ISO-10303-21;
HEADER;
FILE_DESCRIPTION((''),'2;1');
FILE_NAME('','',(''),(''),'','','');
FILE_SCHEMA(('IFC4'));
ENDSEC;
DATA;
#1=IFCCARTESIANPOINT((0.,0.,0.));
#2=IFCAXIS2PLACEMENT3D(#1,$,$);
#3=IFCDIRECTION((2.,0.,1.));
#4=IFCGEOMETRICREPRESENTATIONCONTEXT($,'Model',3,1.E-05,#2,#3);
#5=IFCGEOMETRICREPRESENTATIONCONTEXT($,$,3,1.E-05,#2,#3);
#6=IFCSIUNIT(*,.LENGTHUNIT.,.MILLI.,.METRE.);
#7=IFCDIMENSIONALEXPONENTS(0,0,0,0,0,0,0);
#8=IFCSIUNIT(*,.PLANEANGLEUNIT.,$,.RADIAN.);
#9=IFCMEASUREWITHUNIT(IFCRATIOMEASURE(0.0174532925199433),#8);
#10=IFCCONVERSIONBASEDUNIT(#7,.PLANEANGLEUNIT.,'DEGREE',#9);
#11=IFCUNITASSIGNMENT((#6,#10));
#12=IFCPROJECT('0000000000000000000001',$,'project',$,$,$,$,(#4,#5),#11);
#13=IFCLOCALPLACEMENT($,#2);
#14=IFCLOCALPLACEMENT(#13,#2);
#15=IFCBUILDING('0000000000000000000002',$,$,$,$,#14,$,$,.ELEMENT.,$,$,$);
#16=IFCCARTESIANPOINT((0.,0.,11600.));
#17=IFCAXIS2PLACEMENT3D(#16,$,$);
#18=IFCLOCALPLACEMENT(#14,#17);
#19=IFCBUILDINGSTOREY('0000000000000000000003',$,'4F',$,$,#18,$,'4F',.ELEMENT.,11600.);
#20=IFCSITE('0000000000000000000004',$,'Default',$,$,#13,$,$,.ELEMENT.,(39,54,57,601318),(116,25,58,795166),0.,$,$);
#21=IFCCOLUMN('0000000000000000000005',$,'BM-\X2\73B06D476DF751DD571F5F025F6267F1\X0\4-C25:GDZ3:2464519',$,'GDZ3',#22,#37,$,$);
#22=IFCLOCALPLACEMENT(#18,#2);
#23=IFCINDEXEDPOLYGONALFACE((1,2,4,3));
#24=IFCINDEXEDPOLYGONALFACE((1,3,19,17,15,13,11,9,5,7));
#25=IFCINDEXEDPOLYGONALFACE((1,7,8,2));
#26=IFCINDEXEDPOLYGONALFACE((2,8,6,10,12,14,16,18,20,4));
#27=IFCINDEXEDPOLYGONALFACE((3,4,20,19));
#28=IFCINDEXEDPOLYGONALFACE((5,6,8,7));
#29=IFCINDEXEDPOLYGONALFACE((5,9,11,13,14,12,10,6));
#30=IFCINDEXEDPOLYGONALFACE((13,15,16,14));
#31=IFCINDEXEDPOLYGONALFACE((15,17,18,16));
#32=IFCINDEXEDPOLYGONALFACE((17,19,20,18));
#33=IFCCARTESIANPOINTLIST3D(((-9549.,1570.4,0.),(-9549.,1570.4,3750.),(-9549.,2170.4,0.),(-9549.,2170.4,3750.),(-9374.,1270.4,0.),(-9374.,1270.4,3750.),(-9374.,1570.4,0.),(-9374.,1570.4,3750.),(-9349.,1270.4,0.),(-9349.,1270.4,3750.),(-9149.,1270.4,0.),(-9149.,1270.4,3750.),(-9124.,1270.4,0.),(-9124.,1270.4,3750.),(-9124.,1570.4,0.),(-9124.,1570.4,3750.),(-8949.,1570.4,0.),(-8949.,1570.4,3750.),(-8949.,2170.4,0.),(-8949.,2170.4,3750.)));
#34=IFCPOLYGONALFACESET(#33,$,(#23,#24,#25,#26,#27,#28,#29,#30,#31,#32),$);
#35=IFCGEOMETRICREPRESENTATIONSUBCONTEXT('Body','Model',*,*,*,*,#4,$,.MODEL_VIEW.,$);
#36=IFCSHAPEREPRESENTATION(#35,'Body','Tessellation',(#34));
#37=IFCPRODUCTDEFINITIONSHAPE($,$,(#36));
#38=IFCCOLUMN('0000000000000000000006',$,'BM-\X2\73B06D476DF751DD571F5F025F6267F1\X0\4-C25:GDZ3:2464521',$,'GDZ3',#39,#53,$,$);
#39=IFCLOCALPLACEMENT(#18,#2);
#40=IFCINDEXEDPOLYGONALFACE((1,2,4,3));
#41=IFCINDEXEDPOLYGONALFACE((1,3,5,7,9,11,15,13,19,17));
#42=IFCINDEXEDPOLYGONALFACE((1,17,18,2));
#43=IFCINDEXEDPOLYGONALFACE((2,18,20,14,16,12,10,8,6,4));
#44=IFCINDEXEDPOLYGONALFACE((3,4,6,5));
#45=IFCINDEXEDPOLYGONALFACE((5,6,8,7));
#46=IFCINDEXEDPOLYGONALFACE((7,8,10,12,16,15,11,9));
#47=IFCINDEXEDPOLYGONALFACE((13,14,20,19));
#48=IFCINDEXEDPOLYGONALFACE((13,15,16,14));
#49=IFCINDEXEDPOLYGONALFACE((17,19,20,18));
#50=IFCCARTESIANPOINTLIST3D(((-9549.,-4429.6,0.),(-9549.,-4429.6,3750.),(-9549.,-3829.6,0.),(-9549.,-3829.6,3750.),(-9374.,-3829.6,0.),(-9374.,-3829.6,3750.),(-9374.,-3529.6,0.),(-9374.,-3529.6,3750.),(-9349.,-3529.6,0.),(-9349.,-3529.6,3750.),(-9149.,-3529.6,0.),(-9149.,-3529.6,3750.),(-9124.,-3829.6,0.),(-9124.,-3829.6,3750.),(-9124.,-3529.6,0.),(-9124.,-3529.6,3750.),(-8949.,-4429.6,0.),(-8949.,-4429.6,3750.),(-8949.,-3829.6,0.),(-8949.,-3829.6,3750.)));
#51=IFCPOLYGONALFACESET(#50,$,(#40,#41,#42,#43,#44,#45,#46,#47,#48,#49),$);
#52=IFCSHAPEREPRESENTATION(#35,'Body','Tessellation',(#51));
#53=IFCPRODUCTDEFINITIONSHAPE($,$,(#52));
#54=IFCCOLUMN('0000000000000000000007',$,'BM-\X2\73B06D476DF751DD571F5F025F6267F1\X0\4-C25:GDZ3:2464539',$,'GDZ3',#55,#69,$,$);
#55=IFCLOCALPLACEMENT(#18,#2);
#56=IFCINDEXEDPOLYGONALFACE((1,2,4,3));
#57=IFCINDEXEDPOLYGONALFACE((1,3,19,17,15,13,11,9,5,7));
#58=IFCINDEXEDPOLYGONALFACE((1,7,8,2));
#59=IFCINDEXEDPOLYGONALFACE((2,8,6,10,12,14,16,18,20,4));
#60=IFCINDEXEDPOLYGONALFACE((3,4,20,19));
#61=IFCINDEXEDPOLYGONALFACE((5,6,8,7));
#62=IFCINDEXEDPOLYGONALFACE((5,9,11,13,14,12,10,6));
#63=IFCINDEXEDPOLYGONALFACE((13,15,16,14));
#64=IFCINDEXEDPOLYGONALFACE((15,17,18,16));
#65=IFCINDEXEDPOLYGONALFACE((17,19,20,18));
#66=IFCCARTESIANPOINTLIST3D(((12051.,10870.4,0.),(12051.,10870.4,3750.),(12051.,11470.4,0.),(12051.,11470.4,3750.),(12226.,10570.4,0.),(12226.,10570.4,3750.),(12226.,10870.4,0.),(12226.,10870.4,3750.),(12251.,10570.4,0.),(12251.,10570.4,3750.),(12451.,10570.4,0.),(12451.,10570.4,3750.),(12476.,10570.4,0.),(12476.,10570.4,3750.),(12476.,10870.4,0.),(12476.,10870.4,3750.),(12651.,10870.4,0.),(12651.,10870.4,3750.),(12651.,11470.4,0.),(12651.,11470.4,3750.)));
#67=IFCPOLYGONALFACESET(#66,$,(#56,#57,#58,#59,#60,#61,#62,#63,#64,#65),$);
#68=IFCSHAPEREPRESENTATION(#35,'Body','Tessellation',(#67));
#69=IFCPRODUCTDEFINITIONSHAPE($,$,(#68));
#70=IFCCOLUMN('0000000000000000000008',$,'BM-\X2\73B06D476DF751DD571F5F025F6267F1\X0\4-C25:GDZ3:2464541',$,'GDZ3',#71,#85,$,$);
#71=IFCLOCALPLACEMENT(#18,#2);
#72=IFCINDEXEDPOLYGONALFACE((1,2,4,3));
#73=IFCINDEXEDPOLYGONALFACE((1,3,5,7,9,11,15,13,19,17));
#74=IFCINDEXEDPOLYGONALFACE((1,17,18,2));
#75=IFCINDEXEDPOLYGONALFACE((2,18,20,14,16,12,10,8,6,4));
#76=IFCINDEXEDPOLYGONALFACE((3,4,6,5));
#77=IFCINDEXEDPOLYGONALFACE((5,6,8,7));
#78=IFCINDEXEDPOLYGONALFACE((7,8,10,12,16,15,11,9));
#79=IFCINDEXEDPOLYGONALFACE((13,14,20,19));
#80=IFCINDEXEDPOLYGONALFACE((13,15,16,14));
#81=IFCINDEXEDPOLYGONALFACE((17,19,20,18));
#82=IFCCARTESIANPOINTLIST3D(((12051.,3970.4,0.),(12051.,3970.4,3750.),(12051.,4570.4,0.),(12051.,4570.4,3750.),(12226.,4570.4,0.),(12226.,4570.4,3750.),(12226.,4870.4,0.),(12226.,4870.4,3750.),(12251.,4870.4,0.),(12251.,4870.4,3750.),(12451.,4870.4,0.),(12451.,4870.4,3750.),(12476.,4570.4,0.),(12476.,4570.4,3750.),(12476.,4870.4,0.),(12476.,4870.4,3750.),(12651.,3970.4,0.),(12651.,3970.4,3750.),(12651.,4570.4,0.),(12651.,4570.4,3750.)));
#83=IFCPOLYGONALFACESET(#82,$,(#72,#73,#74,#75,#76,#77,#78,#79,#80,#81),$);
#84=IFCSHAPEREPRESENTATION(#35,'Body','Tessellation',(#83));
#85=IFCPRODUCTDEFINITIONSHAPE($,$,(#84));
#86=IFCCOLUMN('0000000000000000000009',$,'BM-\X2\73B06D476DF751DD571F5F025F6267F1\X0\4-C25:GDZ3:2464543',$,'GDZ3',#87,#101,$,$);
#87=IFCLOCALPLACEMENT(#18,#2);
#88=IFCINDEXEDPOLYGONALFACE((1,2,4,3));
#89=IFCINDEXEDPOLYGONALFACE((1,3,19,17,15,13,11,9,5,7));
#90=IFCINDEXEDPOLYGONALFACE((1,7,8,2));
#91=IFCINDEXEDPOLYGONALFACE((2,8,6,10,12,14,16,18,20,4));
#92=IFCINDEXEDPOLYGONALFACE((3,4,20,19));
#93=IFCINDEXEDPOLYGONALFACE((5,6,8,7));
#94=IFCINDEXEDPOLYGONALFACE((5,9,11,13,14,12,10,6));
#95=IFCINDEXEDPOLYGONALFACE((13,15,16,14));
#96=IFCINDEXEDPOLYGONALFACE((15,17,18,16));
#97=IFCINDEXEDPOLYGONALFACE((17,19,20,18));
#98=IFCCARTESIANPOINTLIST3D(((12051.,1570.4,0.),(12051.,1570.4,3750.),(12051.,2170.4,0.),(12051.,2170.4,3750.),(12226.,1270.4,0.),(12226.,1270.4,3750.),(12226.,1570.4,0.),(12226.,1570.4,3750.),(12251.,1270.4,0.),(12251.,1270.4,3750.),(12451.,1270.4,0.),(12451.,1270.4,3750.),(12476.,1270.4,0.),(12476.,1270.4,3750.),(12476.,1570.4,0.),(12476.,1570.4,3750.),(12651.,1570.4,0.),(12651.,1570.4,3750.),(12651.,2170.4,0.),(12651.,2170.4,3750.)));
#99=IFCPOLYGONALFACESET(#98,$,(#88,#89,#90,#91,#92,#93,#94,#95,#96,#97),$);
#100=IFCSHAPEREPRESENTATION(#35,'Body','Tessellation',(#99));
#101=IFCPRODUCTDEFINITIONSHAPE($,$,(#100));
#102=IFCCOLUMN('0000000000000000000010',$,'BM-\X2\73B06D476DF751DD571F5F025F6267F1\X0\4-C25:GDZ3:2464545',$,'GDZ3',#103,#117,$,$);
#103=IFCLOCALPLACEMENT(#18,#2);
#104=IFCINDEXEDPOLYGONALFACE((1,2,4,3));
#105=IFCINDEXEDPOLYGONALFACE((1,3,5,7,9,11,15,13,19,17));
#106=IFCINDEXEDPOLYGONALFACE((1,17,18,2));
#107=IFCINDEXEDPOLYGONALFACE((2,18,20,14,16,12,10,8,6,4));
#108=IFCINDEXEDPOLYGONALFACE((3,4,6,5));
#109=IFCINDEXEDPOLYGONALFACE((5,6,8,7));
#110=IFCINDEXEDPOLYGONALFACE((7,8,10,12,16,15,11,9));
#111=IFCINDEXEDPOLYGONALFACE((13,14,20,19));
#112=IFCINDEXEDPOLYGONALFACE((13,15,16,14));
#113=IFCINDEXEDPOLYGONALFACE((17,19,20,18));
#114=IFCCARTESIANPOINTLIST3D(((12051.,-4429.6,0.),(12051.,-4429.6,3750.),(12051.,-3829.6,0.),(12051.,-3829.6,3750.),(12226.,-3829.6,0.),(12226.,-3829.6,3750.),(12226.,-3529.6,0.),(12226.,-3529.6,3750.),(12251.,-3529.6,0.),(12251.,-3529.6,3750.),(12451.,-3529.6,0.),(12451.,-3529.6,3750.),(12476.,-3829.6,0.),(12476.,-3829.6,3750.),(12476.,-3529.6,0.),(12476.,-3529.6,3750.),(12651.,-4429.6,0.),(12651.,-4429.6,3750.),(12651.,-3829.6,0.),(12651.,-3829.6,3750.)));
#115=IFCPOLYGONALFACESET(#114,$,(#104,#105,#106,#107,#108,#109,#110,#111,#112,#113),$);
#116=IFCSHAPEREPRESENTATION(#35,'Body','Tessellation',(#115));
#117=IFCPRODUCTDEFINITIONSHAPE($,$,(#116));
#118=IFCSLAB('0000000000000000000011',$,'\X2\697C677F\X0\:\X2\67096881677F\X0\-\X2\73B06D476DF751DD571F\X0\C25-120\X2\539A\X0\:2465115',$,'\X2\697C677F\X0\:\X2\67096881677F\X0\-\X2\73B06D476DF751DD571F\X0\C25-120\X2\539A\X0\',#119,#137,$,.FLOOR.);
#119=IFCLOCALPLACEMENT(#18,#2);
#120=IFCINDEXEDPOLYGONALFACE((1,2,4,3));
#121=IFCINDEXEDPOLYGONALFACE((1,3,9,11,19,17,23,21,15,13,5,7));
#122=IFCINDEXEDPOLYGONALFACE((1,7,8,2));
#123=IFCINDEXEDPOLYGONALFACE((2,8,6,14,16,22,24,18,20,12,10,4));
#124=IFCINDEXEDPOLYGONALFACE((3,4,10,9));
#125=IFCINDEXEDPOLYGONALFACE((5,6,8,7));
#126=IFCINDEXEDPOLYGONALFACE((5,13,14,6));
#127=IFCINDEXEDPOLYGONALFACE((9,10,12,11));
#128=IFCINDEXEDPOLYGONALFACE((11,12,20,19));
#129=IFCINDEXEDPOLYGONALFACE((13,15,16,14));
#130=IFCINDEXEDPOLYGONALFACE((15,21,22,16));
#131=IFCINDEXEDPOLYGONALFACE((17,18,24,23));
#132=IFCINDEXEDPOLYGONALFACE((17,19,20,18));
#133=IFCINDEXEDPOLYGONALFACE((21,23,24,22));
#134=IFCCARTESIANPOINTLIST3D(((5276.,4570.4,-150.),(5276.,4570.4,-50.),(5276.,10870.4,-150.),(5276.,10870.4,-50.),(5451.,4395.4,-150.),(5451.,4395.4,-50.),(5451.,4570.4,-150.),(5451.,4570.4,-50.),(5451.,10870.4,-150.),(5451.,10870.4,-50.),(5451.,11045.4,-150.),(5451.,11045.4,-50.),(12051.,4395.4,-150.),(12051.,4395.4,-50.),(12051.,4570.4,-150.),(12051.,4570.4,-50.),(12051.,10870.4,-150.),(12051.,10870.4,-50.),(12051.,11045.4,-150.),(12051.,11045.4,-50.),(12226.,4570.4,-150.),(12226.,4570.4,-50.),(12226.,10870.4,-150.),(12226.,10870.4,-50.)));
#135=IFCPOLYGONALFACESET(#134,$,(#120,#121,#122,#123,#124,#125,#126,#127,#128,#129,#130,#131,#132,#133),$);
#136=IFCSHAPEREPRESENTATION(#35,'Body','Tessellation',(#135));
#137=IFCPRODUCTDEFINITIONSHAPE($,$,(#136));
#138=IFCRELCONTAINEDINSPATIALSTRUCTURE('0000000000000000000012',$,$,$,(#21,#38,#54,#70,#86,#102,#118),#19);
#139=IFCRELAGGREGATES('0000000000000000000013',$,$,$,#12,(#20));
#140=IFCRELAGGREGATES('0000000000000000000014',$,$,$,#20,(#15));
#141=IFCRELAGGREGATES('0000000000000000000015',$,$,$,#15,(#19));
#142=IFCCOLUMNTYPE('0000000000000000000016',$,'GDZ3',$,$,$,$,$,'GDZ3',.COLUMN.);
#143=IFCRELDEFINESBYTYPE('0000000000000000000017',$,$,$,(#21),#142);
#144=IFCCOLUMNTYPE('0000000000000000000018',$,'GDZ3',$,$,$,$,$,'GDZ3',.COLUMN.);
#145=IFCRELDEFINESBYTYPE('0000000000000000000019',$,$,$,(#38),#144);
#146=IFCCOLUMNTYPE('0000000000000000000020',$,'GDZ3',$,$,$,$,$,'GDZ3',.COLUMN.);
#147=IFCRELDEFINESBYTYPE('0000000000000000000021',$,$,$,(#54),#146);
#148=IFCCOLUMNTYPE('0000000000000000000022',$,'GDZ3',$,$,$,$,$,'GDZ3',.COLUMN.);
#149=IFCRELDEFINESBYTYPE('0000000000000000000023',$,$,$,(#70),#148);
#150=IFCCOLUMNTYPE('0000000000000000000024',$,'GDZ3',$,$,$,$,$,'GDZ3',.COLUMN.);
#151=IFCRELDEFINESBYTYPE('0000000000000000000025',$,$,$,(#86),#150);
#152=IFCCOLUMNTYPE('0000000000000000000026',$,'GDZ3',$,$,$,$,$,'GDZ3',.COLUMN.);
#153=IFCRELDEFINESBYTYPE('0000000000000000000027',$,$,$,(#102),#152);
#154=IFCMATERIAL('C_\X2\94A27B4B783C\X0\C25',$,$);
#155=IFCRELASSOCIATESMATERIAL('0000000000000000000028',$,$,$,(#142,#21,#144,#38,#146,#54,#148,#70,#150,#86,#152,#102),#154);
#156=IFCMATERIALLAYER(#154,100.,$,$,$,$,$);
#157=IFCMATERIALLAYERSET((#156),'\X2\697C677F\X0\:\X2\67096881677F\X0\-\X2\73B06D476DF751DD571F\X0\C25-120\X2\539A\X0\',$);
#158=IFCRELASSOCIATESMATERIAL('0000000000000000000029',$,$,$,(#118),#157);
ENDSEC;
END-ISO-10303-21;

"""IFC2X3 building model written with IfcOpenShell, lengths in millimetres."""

from ifc_helpers import new_model, entity, si_unit, converted_unit, direction, frame, origin, place, context, subcontext, project, spatial, polyline, outline, extrude, source, transform, mapped, material, layer, layer_set, layer_usage, type_object, type_shapes, element, save


model = new_model("IFC2X3")

# Units and contexts
model_context = context("Model", 3, precision=1e-05, world=origin(), true_north=direction((2.0, 0.0, 1.0)))
context_of_model = context(None, 3, precision=1e-05, world=origin(), true_north=direction((2.0, 0.0, 1.0)))
body_context = subcontext(model_context, "Body", "Model", "MODEL_VIEW")
ifc_project = project(units=[si_unit("LENGTHUNIT", "METRE", prefix="MILLI"), converted_unit("PLANEANGLEUNIT", "DEGREE", entity("IfcRatioMeasure", 0.0174532925199433), si_unit("PLANEANGLEUNIT", "RADIAN"), dimensions=[0, 0, 0, 0, 0, 0, 0])], contexts=[model_context, context_of_model])

# Site, building, storey
site_placement = place(None, origin())
site = spatial("IfcSite", under=ifc_project, at=site_placement, Name="Default", CompositionType="ELEMENT", RefLatitude=(39, 54, 57, 601318), RefLongitude=(116, 25, 58, 795166), RefElevation=0.0)
building_placement = place(site_placement, origin())
building = spatial("IfcBuilding", under=site, at=building_placement, CompositionType="ELEMENT")
storey_placement = place(building_placement, frame((0.0, 0.0, 11600.0)))
storey = spatial("IfcBuildingStorey", under=building, at=storey_placement, Name="4F", LongName="4F", CompositionType="ELEMENT", Elevation=11600.0)

# Columns
ifc_material = material(Name="C_钢筋砼C25")
column_type_1 = type_object("IfcColumnType", Name="GDZ3", ElementType="GDZ3", PredefinedType="COLUMN", material=ifc_material)
shared_shape_1 = source(origin(), body_context, "Body", "SweptSolid", [
    extrude(outline(polyline([(0.0, -300.0), (600.0, -300.0), (600.0, 300.0), (0.0, 300.0), (0.0, 125.0), (-300.0, 125.0), (-300.0, 100.0), (-300.0, -100.0), (-300.0, -125.0), (0.0, -125.0), (0.0, -300.0)])), frame((-9249.0, 1570.4, 11600.0), z_axis=(0.0, 0.0, 1.0), x_axis=(0.0, 1.0, 0.0)), (0.0, 0.0, 1.0), 3750.0),
])
type_shapes(column_type_1, [shared_shape_1])
column_1_placement = place(storey_placement, frame((0.0, 0.0, -11600.0)))
element("IfcColumn", 1, at=column_1_placement, inside=storey, type_object=column_type_1, material=ifc_material, Name="BM-现浇混凝土异形柱4-C25:GDZ3:2464519", ObjectType="GDZ3", context=body_context, shape_type="MappedRepresentation", body=[
    mapped(shared_shape_1, transform((0.0, 0.0, 0.0), scale=1.0)),
])
column_type_2 = type_object("IfcColumnType", Name="GDZ3", ElementType="GDZ3", PredefinedType="COLUMN", material=ifc_material)
shared_shape_2 = source(origin(), body_context, "Body", "SweptSolid", [
    extrude(outline(polyline([(0.0, -300.0), (600.0, -300.0), (600.0, 300.0), (0.0, 300.0), (0.0, 125.0), (-300.0, 125.0), (-300.0, 100.0), (-300.0, -100.0), (-300.0, -125.0), (0.0, -125.0), (0.0, -300.0)])), frame((-9249.0, -3829.6, 11600.0), z_axis=(0.0, 0.0, 1.0), x_axis=(0.0, -1.0, 0.0)), (0.0, 0.0, 1.0), 3750.0),
])
type_shapes(column_type_2, [shared_shape_2])
column_2_placement = place(storey_placement, frame((0.0, 0.0, -11600.0)))
element("IfcColumn", 2, at=column_2_placement, inside=storey, type_object=column_type_2, material=ifc_material, Name="BM-现浇混凝土异形柱4-C25:GDZ3:2464521", ObjectType="GDZ3", context=body_context, shape_type="MappedRepresentation", body=[
    mapped(shared_shape_2, transform((0.0, 0.0, 0.0), scale=1.0)),
])
column_type_3 = type_object("IfcColumnType", Name="GDZ3", ElementType="GDZ3", PredefinedType="COLUMN", material=ifc_material)
shared_shape_3 = source(origin(), body_context, "Body", "SweptSolid", [
    extrude(outline(polyline([(0.0, -300.0), (600.0, -300.0), (600.0, 300.0), (0.0, 300.0), (0.0, 125.0), (-300.0, 125.0), (-300.0, 100.0), (-300.0, -100.0), (-300.0, -125.0), (0.0, -125.0), (0.0, -300.0)])), frame((12351.0, 10870.4, 11600.0), z_axis=(0.0, 0.0, 1.0), x_axis=(0.0, 1.0, 0.0)), (0.0, 0.0, 1.0), 3750.0),
])
type_shapes(column_type_3, [shared_shape_3])
column_3_placement = place(storey_placement, frame((0.0, 0.0, -11600.0)))
element("IfcColumn", 3, at=column_3_placement, inside=storey, type_object=column_type_3, material=ifc_material, Name="BM-现浇混凝土异形柱4-C25:GDZ3:2464539", ObjectType="GDZ3", context=body_context, shape_type="MappedRepresentation", body=[
    mapped(shared_shape_3, transform((0.0, 0.0, 0.0), scale=1.0)),
])
column_type_4 = type_object("IfcColumnType", Name="GDZ3", ElementType="GDZ3", PredefinedType="COLUMN", material=ifc_material)
shared_shape_4 = source(origin(), body_context, "Body", "SweptSolid", [
    extrude(outline(polyline([(0.0, -300.0), (600.0, -300.0), (600.0, 300.0), (0.0, 300.0), (0.0, 125.0), (-300.0, 125.0), (-300.0, 100.0), (-300.0, -100.0), (-300.0, -125.0), (0.0, -125.0), (0.0, -300.0)])), frame((12351.0, 4570.4, 11600.0), z_axis=(0.0, 0.0, 1.0), x_axis=(0.0, -1.0, 0.0)), (0.0, 0.0, 1.0), 3750.0),
])
type_shapes(column_type_4, [shared_shape_4])
column_4_placement = place(storey_placement, frame((0.0, 0.0, -11600.0)))
element("IfcColumn", 4, at=column_4_placement, inside=storey, type_object=column_type_4, material=ifc_material, Name="BM-现浇混凝土异形柱4-C25:GDZ3:2464541", ObjectType="GDZ3", context=body_context, shape_type="MappedRepresentation", body=[
    mapped(shared_shape_4, transform((0.0, 0.0, 0.0), scale=1.0)),
])
column_type_5 = type_object("IfcColumnType", Name="GDZ3", ElementType="GDZ3", PredefinedType="COLUMN", material=ifc_material)
shared_shape_5 = source(origin(), body_context, "Body", "SweptSolid", [
    extrude(outline(polyline([(0.0, -300.0), (600.0, -300.0), (600.0, 300.0), (0.0, 300.0), (0.0, 125.0), (-300.0, 125.0), (-300.0, 100.0), (-300.0, -100.0), (-300.0, -125.0), (0.0, -125.0), (0.0, -300.0)])), frame((12351.0, 1570.4, 11600.0), z_axis=(0.0, 0.0, 1.0), x_axis=(0.0, 1.0, 0.0)), (0.0, 0.0, 1.0), 3750.0),
])
type_shapes(column_type_5, [shared_shape_5])
column_5_placement = place(storey_placement, frame((0.0, 0.0, -11600.0)))
element("IfcColumn", 5, at=column_5_placement, inside=storey, type_object=column_type_5, material=ifc_material, Name="BM-现浇混凝土异形柱4-C25:GDZ3:2464543", ObjectType="GDZ3", context=body_context, shape_type="MappedRepresentation", body=[
    mapped(shared_shape_5, transform((0.0, 0.0, 0.0), scale=1.0)),
])
column_type_6 = type_object("IfcColumnType", Name="GDZ3", ElementType="GDZ3", PredefinedType="COLUMN", material=ifc_material)
shared_shape_6 = source(origin(), body_context, "Body", "SweptSolid", [
    extrude(outline(polyline([(0.0, -300.0), (600.0, -300.0), (600.0, 300.0), (0.0, 300.0), (0.0, 125.0), (-300.0, 125.0), (-300.0, 100.0), (-300.0, -100.0), (-300.0, -125.0), (0.0, -125.0), (0.0, -300.0)])), frame((12351.0, -3829.6, 11600.0), z_axis=(0.0, 0.0, 1.0), x_axis=(0.0, -1.0, 0.0)), (0.0, 0.0, 1.0), 3750.0),
])
type_shapes(column_type_6, [shared_shape_6])
column_6_placement = place(storey_placement, frame((0.0, 0.0, -11600.0)))
element("IfcColumn", 6, at=column_6_placement, inside=storey, type_object=column_type_6, material=ifc_material, Name="BM-现浇混凝土异形柱4-C25:GDZ3:2464545", ObjectType="GDZ3", context=body_context, shape_type="MappedRepresentation", body=[
    mapped(shared_shape_6, transform((0.0, 0.0, 0.0), scale=1.0)),
])

# Slab
ifc_layer = layer(ifc_material, 100.0)
ifc_layer_set = layer_set([ifc_layer], Name="楼板:有梁板-现浇混凝土C25-120厚")
ifc_layer_usage = layer_usage(ifc_layer_set, "AXIS3", "POSITIVE", 0.0)
slab_1_placement = place(storey_placement, origin())
element("IfcSlab", 7, at=slab_1_placement, inside=storey, material=ifc_layer_usage, Name="楼板:有梁板-现浇混凝土C25-120厚:2465115", ObjectType="楼板:有梁板-现浇混凝土C25-120厚", PredefinedType="FLOOR", context=body_context, shape_type="SweptSolid", body=[
    extrude(outline(polyline([(-3150.0, -3475.0), (3150.0, -3475.0), (3150.0, -3300.0), (3325.0, -3300.0), (3325.0, 3300.0), (3150.0, 3300.0), (3150.0, 3475.0), (-3150.0, 3475.0), (-3150.0, 3300.0), (-3325.0, 3300.0), (-3325.0, -3300.0), (-3150.0, -3300.0), (-3150.0, -3475.0)])), frame((8751.0, 7720.4, -50.0), z_axis=(0.0, 0.0, -1.0), x_axis=(0.0, 1.0, 0.0)), (0.0, 0.0, 1.0), 100.0),
])

save(model, "model.ifc")
